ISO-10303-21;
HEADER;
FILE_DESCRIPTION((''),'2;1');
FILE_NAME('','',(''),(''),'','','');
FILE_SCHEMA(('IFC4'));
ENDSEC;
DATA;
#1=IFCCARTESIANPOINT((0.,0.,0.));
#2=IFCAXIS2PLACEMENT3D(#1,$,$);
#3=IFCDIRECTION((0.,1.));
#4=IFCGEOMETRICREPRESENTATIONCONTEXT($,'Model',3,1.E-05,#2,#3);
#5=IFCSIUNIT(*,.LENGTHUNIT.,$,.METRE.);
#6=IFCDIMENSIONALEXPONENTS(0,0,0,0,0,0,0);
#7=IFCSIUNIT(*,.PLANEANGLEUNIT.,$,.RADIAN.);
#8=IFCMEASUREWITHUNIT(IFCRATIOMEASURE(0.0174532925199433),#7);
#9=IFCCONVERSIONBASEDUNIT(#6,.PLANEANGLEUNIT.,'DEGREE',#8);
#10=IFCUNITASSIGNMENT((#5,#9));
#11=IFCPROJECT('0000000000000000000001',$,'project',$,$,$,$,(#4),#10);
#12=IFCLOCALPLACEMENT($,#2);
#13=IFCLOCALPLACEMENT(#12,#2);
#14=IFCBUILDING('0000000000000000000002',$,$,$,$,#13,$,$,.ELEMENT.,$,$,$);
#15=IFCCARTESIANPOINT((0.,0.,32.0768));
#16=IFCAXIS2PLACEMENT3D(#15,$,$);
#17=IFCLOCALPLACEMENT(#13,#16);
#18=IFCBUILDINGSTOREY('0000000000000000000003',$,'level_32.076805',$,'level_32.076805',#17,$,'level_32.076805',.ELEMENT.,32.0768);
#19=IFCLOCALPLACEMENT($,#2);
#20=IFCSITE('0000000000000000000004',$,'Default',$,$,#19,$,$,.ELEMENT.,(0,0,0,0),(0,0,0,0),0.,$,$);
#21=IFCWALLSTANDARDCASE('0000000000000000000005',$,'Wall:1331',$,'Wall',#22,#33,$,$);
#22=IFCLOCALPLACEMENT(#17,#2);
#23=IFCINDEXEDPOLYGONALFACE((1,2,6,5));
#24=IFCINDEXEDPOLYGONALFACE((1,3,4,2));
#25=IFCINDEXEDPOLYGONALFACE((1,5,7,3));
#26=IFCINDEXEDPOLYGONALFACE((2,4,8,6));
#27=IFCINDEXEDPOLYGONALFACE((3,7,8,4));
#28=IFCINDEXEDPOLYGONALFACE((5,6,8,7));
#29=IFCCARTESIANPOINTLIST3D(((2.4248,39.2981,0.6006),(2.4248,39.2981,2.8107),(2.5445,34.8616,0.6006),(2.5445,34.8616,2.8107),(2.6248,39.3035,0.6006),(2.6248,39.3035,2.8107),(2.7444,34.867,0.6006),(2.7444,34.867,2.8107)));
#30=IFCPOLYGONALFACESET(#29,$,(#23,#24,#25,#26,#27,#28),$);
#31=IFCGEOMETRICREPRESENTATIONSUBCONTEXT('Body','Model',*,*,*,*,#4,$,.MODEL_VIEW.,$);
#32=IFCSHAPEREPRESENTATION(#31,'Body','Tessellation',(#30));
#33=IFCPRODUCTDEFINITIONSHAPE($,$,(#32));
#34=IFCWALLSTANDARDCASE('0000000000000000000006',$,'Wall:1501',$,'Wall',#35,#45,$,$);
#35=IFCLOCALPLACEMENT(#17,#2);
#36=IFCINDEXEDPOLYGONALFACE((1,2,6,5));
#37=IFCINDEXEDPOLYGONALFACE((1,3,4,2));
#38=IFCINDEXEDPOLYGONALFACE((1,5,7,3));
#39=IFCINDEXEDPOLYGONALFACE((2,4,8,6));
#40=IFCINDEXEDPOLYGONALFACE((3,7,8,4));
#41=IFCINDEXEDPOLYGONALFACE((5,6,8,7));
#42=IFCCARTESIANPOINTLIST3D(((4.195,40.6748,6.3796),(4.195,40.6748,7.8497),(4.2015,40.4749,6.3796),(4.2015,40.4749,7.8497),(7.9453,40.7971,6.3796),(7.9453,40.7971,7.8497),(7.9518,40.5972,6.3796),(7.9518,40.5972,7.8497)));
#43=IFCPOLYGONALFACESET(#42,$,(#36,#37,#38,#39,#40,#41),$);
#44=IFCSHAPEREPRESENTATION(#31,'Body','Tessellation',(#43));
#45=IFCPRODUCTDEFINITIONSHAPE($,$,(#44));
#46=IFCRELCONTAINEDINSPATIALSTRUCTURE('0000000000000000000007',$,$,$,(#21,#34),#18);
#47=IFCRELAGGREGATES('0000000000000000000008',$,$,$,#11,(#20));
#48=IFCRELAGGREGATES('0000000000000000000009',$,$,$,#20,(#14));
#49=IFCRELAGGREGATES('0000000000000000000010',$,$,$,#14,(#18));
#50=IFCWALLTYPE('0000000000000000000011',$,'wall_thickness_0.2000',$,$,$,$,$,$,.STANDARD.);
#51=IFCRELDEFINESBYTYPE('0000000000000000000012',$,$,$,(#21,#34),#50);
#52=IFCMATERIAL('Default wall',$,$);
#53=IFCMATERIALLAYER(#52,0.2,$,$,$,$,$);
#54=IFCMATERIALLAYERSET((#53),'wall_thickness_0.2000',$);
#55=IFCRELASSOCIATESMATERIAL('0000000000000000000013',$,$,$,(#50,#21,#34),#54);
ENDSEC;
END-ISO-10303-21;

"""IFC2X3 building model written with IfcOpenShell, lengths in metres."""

from ifc_helpers import new_model, entity, si_unit, converted_unit, direction, frame, origin, place, context, subcontext, project, spatial, polyline, outline, extrude, material, layer, layer_set, layer_usage, type_object, element, save


model = new_model("IFC2X3")

# Units and contexts
model_context = context("Model", 3, precision=1e-05, world=origin(), true_north=direction((0.0, 1.0)))
body_context = subcontext(model_context, "Body", "Model", "MODEL_VIEW")
ifc_project = project(units=[si_unit("LENGTHUNIT", "METRE"), converted_unit("PLANEANGLEUNIT", "DEGREE", entity("IfcRatioMeasure", 0.0174532925199433), si_unit("PLANEANGLEUNIT", "RADIAN"), dimensions=[0, 0, 0, 0, 0, 0, 0])], contexts=[model_context])

# Site, building, storey
site_placement = place(None, origin())
site = spatial("IfcSite", under=ifc_project, at=site_placement, Name="Default", CompositionType="ELEMENT", RefLatitude=(0, 0, 0, 0), RefLongitude=(0, 0, 0, 0), RefElevation=0.0)
placement_1 = place(None, origin())
building_placement = place(placement_1, origin())
building = spatial("IfcBuilding", under=site, at=building_placement, CompositionType="ELEMENT")
storey_placement = place(building_placement, frame((0.0, 0.0, 32.0768)))
storey = spatial("IfcBuildingStorey", under=building, at=storey_placement, Name="level_32.076805", ObjectType="level_32.076805", LongName="level_32.076805", CompositionType="ELEMENT", Elevation=32.0768)

# Walls
ifc_material_1 = material(Name="Default wall")
ifc_layer = layer(ifc_material_1, 0.2)
ifc_layer_set = layer_set([ifc_layer], Name="wall_thickness_0.2000")
ifc_layer_usage = layer_usage(ifc_layer_set, "AXIS2", "POSITIVE", -0.1)
wall_type = type_object("IfcWallType", Name="wall_thickness_0.2000", PredefinedType="STANDARD", material=ifc_layer_set)
placement_2 = place(building_placement, frame((0.0, 0.0, 32.6774)))
wall_1_placement = place(placement_2, frame((2.5248, 39.3008, 0.0), z_axis=(0.0, 0.0, 1.0), x_axis=(0.026953, -0.999637, 0.0)))
element("IfcWallStandardCase", 1, at=wall_1_placement, inside=storey, type_object=wall_type, material=ifc_layer_usage, Name="Wall:1331", ObjectType="Wall", context=body_context, shape_type="SweptSolid", body=[
    extrude(outline(polyline([(4.4381, -0.1), (4.4381, 0.1), (0.0, 0.1), (0.0, -0.1), (4.4381, -0.1)])), origin(), (0.0, 0.0, 1.0), 2.2102),
])
placement_3 = place(building_placement, frame((0.0, 0.0, 38.4564)))
wall_2_placement = place(placement_3, frame((4.1983, 40.5749, 0.0), z_axis=(0.0, 0.0, 1.0), x_axis=(0.999469, 0.032589, 0.0)))
element("IfcWallStandardCase", 2, at=wall_2_placement, inside=storey, type_object=wall_type, material=ifc_layer_usage, Name="Wall:1501", ObjectType="Wall", context=body_context, shape_type="SweptSolid", body=[
    extrude(outline(polyline([(3.7523, -0.1), (3.7523, 0.1), (0.0, 0.1), (0.0, -0.1), (3.7523, -0.1)])), origin(), (0.0, 0.0, 1.0), 1.4701),
])

save(model, "model.ifc")
